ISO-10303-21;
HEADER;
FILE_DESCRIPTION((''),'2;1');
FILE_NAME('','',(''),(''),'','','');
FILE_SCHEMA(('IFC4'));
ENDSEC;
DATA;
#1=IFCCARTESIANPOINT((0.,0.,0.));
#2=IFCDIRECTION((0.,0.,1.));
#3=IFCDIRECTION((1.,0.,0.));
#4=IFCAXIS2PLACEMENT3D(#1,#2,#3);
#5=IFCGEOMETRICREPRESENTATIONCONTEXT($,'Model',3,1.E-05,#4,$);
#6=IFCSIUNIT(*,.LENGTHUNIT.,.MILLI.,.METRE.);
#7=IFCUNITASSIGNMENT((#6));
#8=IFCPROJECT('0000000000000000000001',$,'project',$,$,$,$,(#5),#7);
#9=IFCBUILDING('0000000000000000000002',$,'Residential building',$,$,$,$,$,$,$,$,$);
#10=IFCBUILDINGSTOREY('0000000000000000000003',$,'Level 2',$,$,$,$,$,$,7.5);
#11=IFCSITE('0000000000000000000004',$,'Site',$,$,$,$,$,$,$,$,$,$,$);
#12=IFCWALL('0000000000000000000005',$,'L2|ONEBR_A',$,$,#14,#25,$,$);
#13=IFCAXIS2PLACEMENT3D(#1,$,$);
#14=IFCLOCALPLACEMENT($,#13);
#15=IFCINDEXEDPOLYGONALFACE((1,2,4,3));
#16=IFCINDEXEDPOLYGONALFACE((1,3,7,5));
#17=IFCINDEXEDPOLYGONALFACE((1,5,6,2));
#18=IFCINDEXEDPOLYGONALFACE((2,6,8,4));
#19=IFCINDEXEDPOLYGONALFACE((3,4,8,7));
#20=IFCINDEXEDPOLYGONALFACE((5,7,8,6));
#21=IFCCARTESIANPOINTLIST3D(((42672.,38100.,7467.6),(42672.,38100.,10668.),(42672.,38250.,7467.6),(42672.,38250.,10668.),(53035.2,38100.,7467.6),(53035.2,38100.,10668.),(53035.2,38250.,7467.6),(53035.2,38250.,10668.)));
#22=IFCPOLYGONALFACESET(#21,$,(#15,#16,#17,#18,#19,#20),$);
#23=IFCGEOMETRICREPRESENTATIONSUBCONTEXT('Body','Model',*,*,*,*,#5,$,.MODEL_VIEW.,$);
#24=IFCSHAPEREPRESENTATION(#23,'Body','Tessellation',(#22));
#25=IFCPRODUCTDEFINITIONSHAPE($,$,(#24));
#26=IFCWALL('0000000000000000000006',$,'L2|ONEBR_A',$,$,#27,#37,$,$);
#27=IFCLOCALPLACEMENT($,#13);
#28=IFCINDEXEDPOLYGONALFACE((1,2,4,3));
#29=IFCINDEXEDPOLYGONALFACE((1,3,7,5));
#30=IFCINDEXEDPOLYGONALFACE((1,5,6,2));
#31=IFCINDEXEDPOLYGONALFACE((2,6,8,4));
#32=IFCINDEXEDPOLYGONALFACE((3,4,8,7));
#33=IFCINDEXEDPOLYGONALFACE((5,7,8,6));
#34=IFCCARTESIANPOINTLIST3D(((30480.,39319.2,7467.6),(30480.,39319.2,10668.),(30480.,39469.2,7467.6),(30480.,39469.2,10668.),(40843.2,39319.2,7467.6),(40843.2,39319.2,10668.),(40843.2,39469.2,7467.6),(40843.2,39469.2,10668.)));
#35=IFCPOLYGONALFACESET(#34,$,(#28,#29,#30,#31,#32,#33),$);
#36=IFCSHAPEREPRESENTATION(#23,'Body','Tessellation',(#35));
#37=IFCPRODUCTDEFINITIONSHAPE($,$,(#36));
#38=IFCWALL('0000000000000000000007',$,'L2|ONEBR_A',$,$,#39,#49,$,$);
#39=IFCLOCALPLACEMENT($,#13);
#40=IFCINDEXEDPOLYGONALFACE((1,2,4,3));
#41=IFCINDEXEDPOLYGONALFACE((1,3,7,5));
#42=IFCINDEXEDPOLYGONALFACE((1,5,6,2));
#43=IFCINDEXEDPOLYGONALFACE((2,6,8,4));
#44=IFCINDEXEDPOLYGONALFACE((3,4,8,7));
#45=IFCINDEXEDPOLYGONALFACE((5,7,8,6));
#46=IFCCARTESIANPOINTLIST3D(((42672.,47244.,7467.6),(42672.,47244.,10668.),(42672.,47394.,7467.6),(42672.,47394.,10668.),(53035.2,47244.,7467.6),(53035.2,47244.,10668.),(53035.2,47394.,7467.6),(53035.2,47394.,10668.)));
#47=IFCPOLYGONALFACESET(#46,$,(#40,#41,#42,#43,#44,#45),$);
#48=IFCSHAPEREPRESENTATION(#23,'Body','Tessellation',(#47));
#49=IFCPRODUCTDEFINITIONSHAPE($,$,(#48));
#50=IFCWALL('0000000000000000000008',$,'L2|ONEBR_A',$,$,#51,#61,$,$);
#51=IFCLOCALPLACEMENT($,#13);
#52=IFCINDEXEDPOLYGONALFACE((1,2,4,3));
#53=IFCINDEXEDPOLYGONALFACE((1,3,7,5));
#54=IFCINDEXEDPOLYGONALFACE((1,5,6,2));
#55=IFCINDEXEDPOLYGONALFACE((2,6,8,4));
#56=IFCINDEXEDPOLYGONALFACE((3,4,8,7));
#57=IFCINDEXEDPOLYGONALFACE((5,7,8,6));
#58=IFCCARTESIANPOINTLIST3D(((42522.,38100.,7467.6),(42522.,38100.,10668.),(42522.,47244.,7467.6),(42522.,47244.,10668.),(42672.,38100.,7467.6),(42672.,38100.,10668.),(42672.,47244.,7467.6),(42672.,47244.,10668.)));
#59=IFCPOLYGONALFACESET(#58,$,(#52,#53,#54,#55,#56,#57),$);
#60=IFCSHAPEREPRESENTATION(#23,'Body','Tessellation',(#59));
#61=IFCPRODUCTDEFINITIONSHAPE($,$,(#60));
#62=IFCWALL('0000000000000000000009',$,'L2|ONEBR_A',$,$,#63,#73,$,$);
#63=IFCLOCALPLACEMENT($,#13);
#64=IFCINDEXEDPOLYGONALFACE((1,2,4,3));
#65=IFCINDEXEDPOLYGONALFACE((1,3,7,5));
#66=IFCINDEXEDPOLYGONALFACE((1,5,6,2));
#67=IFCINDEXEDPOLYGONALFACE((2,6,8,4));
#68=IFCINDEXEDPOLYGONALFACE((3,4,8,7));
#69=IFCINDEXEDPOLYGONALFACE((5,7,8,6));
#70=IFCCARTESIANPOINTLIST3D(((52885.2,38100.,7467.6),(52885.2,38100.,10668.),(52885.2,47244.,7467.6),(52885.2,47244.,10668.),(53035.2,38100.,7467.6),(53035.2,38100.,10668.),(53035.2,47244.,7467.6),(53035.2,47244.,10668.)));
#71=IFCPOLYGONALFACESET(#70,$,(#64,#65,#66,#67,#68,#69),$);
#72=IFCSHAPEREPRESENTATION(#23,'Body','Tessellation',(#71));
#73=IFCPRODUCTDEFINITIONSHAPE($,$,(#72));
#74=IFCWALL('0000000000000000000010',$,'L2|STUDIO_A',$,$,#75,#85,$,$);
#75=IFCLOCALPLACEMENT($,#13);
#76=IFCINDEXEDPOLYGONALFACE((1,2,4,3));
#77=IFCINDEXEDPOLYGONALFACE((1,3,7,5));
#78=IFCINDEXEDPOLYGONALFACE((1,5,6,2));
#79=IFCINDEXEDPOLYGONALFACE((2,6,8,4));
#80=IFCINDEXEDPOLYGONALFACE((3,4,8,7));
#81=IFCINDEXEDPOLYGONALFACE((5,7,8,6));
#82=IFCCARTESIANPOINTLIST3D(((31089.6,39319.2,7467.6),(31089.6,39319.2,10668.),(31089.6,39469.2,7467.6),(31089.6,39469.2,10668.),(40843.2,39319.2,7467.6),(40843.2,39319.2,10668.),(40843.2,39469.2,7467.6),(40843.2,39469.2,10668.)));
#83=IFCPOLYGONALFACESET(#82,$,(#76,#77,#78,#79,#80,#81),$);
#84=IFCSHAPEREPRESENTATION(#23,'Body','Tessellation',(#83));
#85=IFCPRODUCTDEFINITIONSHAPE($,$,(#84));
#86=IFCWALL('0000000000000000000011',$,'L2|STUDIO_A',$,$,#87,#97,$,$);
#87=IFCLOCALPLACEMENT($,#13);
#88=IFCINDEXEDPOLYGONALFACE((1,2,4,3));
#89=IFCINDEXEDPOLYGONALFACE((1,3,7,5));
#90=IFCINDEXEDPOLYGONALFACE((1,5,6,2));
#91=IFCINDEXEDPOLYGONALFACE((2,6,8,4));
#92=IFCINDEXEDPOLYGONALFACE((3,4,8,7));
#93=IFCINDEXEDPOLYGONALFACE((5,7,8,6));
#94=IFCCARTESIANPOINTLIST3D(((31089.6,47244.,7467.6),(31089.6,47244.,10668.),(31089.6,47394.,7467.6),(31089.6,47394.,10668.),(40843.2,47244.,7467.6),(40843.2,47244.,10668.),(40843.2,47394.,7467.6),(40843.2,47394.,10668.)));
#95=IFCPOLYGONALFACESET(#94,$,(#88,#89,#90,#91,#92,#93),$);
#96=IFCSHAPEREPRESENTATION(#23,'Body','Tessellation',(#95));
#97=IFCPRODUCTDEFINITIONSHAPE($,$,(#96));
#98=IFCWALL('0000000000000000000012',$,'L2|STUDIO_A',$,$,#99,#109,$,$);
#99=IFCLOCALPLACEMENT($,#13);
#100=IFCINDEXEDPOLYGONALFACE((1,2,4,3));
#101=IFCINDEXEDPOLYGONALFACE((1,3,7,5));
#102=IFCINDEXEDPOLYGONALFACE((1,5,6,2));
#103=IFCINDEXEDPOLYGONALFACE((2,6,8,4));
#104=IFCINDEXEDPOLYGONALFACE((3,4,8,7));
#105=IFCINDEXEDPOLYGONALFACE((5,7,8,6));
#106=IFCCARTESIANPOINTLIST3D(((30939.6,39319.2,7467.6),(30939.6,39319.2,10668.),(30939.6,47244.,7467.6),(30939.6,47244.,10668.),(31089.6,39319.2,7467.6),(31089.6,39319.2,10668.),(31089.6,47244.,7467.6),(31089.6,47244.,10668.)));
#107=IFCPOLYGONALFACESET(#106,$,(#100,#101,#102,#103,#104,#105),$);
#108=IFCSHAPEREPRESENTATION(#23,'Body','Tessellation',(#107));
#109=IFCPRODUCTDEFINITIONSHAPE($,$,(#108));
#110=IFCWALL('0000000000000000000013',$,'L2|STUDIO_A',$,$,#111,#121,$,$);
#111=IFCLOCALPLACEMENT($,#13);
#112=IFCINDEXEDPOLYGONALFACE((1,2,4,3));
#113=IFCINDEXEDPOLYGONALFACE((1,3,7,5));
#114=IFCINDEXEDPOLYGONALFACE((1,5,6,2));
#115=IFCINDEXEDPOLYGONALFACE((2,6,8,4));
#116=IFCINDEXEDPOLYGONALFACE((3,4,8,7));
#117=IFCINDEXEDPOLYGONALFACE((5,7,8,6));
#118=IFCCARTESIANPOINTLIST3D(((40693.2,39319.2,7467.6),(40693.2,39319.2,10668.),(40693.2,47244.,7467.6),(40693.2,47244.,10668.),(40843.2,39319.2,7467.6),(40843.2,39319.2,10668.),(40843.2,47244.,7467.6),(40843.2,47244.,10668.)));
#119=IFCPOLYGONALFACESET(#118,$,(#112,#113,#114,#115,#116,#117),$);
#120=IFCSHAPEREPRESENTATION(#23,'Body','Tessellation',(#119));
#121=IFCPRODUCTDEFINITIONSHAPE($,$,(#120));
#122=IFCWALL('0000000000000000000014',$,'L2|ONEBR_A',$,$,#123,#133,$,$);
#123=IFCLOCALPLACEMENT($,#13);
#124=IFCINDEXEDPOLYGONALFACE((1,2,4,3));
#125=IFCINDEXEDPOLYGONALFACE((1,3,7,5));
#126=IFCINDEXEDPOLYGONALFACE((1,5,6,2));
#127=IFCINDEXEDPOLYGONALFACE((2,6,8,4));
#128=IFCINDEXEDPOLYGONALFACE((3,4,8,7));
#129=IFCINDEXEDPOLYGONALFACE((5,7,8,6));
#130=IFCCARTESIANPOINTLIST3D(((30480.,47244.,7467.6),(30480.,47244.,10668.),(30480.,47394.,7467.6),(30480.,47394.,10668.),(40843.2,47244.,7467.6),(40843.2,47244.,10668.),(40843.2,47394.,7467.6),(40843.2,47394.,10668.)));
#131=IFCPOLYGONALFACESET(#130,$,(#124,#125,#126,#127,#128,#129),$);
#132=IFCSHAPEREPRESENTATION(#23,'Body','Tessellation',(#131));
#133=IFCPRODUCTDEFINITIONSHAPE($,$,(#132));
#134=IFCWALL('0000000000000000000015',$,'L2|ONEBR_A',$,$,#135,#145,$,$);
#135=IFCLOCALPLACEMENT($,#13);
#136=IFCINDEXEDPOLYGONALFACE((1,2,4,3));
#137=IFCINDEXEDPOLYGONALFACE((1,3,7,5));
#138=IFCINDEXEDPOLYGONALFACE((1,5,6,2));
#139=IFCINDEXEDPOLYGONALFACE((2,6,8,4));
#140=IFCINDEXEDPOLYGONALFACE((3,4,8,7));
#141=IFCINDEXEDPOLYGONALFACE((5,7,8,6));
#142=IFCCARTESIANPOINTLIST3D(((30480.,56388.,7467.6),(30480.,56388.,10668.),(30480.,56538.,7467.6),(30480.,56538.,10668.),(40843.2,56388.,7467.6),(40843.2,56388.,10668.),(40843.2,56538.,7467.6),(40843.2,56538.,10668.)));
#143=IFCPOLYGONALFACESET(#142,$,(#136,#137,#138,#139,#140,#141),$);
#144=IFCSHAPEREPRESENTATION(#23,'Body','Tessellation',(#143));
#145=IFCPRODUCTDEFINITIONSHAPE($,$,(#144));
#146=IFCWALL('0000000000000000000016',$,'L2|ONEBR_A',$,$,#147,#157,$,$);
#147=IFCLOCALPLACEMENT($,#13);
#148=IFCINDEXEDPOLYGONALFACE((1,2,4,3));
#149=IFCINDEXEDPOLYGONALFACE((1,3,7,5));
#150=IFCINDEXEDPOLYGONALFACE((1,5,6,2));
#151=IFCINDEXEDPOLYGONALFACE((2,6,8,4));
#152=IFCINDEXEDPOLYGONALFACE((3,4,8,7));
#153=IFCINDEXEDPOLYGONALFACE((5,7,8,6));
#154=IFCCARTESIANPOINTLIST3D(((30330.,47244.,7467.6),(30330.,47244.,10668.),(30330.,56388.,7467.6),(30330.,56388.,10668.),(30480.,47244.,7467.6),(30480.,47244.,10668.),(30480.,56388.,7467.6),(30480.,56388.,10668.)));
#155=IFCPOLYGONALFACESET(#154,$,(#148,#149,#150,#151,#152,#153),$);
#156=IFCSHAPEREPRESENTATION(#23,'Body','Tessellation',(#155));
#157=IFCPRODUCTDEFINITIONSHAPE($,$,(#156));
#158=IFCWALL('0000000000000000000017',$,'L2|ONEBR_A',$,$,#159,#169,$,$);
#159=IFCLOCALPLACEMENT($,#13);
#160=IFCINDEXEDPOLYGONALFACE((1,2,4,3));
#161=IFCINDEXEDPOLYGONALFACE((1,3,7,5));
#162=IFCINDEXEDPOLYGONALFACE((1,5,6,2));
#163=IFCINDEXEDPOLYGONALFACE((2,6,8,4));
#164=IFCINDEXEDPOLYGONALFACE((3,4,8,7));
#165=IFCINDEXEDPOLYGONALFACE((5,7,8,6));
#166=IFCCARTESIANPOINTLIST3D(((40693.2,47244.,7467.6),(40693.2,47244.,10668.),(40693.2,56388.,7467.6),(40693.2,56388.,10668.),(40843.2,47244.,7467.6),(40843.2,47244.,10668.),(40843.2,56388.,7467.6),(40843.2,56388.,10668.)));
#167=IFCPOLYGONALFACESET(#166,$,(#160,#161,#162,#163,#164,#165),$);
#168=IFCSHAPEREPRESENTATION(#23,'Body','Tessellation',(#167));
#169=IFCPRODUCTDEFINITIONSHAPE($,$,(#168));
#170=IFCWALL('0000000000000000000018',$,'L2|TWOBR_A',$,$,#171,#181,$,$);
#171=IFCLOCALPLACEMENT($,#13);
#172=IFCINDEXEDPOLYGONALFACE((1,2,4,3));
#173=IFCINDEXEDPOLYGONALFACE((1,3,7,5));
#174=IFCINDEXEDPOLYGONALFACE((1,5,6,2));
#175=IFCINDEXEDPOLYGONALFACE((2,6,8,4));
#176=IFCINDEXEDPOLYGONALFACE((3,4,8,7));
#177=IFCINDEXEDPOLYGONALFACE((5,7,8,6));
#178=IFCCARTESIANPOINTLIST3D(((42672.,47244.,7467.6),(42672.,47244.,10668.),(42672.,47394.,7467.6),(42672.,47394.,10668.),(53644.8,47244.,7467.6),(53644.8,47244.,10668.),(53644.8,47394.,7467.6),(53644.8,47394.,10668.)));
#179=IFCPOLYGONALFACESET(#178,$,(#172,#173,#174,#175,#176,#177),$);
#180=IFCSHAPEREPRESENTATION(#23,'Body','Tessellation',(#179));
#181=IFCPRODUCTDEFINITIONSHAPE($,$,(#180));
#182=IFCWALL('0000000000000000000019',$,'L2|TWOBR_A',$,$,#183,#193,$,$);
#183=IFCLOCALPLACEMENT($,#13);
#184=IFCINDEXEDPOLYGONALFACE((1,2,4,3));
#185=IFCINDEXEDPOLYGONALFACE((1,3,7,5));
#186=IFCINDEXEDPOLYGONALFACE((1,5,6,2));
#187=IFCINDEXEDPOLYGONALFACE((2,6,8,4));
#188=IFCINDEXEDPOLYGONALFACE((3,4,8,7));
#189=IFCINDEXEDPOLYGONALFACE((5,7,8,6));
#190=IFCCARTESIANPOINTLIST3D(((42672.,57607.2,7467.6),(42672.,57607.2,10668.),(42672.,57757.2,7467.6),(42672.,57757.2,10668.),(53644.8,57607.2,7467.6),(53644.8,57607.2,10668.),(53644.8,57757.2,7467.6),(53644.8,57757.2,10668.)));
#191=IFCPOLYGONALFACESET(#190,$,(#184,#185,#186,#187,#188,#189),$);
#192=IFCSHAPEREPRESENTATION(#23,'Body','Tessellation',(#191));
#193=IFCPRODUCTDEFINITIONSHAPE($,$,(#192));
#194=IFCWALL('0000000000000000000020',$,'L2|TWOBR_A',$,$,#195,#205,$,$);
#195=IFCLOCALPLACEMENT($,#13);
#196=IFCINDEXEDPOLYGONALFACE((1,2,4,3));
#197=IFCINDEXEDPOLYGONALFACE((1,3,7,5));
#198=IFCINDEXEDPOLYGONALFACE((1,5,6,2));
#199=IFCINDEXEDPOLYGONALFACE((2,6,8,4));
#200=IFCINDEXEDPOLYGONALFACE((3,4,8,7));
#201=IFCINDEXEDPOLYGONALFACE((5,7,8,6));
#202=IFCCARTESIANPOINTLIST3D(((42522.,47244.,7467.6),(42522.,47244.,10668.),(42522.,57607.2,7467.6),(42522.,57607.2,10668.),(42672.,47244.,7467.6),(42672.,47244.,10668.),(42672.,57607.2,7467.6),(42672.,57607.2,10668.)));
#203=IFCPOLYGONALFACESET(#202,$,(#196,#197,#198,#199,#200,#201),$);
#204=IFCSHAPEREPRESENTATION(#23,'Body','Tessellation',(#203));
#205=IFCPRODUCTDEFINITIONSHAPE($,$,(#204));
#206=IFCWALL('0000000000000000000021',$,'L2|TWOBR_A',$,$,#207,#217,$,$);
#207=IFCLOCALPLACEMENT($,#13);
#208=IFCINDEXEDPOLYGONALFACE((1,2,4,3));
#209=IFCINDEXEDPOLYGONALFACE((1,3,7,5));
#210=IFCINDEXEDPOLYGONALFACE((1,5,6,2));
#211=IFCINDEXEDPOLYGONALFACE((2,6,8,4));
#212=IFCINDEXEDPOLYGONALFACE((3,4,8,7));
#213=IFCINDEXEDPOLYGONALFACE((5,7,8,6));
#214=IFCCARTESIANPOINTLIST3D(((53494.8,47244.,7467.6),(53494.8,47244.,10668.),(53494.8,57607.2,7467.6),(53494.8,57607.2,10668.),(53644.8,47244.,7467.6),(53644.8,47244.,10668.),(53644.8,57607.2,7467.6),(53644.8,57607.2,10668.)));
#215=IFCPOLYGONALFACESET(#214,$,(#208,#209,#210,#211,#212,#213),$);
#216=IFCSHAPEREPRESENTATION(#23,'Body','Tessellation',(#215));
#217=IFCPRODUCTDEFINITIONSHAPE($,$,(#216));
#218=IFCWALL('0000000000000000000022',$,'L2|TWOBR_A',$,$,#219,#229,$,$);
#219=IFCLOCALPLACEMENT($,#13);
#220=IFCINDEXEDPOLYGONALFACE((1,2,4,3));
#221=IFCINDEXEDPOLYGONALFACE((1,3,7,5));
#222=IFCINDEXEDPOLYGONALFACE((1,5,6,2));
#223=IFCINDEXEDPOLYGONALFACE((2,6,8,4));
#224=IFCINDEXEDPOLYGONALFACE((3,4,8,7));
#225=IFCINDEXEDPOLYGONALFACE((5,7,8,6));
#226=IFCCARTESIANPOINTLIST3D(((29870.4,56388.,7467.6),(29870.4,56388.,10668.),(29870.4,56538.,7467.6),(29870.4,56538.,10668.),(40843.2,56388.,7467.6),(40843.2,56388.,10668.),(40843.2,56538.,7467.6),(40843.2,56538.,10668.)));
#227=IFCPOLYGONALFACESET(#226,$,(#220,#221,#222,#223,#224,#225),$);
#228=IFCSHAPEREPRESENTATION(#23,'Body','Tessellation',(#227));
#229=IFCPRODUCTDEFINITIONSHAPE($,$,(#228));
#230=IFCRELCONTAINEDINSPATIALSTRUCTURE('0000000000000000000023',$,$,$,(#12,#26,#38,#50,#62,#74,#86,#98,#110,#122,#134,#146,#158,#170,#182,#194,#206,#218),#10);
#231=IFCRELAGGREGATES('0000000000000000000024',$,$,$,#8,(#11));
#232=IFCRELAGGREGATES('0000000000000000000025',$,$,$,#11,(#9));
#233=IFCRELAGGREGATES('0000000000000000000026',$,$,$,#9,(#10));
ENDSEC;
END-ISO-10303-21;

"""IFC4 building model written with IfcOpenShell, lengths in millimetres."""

from ifc_helpers import new_model, si_unit, frame, origin_with_axes, place, context, subcontext, project, spatial, indexed_curve, outline, extrude, element, save


model = new_model("IFC4")

# Units and contexts
model_context = context("Model", 3, precision=1e-05, world=origin_with_axes())
body_context = subcontext(model_context, "Body", "Model", "MODEL_VIEW")
ifc_project = project(units=[si_unit("LENGTHUNIT", "METRE", prefix="MILLI")], contexts=[model_context])

# Site, building, storey
site = spatial("IfcSite", under=ifc_project, Name="Site")
building = spatial("IfcBuilding", under=site, Name="Residential building")
storey = spatial("IfcBuildingStorey", under=building, Name="Level 2", Elevation=7.5)

# Walls
for number, where, z_axis, x_axis, name in (
    (1, (42672.0, 38100.0, 7467.6), (0.0, 0.0, 1.0), (1.0, 0.0, 0.0), "L2|ONEBR_A"),
    (2, (30480.0, 39319.2, 7467.6), (0.0, 0.0, 1.0), (1.0, 0.0, 0.0), "L2|ONEBR_A"),
    (3, (42672.0, 47244.0, 7467.6), (0.0, 0.0, 1.0), (1.0, 0.0, 0.0), "L2|ONEBR_A"),
):
    element("IfcWall", number, at=place(None, frame(where, z_axis=z_axis, x_axis=x_axis)), inside=storey, Name=name, context=body_context, shape_type="SweptSolid", body=[
        extrude(outline(indexed_curve([(0.0, 0.0), (0.0, 150.0), (10363.2, 150.0), (10363.2, 0.0), (0.0, 0.0)], self_intersect=False)), origin_with_axes(), (0.0, 0.0, 1.0), 3200.4),
    ])
for number, where, z_axis, x_axis, name in (
    (4, (42672.0, 38100.0, 7467.6), (0.0, 0.0, 1.0), (0.0, 1.0, 0.0), "L2|ONEBR_A"),
    (5, (53035.2, 38100.0, 7467.6), (0.0, 0.0, 1.0), (0.0, 1.0, 0.0), "L2|ONEBR_A"),
):
    element("IfcWall", number, at=place(None, frame(where, z_axis=z_axis, x_axis=x_axis)), inside=storey, Name=name, context=body_context, shape_type="SweptSolid", body=[
        extrude(outline(indexed_curve([(0.0, 0.0), (0.0, 150.0), (9144.0, 150.0), (9144.0, 0.0), (0.0, 0.0)], self_intersect=False)), origin_with_axes(), (0.0, 0.0, 1.0), 3200.4),
    ])
for number, where, z_axis, x_axis, name in (
    (6, (31089.6, 39319.2, 7467.6), (0.0, 0.0, 1.0), (1.0, 0.0, 0.0), "L2|STUDIO_A"),
    (7, (31089.6, 47244.0, 7467.6), (0.0, 0.0, 1.0), (1.0, 0.0, 0.0), "L2|STUDIO_A"),
):
    element("IfcWall", number, at=place(None, frame(where, z_axis=z_axis, x_axis=x_axis)), inside=storey, Name=name, context=body_context, shape_type="SweptSolid", body=[
        extrude(outline(indexed_curve([(0.0, 0.0), (0.0, 150.0), (9753.6, 150.0), (9753.6, 0.0), (0.0, 0.0)], self_intersect=False)), origin_with_axes(), (0.0, 0.0, 1.0), 3200.4),
    ])
for number, where, z_axis, x_axis, name in (
    (8, (31089.6, 39319.2, 7467.6), (0.0, 0.0, 1.0), (0.0, 1.0, 0.0), "L2|STUDIO_A"),
    (9, (40843.2, 39319.2, 7467.6), (0.0, 0.0, 1.0), (0.0, 1.0, 0.0), "L2|STUDIO_A"),
):
    element("IfcWall", number, at=place(None, frame(where, z_axis=z_axis, x_axis=x_axis)), inside=storey, Name=name, context=body_context, shape_type="SweptSolid", body=[
        extrude(outline(indexed_curve([(0.0, 0.0), (0.0, 150.0), (7924.8, 150.0), (7924.8, 0.0), (0.0, 0.0)], self_intersect=False)), origin_with_axes(), (0.0, 0.0, 1.0), 3200.4),
    ])
for number, where, z_axis, x_axis, name in (
    (10, (30480.0, 47244.0, 7467.6), (0.0, 0.0, 1.0), (1.0, 0.0, 0.0), "L2|ONEBR_A"),
    (11, (30480.0, 56388.0, 7467.6), (0.0, 0.0, 1.0), (1.0, 0.0, 0.0), "L2|ONEBR_A"),
):
    element("IfcWall", number, at=place(None, frame(where, z_axis=z_axis, x_axis=x_axis)), inside=storey, Name=name, context=body_context, shape_type="SweptSolid", body=[
        extrude(outline(indexed_curve([(0.0, 0.0), (0.0, 150.0), (10363.2, 150.0), (10363.2, 0.0), (0.0, 0.0)], self_intersect=False)), origin_with_axes(), (0.0, 0.0, 1.0), 3200.4),
    ])
for number, where, z_axis, x_axis, name in (
    (12, (30480.0, 47244.0, 7467.6), (0.0, 0.0, 1.0), (0.0, 1.0, 0.0), "L2|ONEBR_A"),
    (13, (40843.2, 47244.0, 7467.6), (0.0, 0.0, 1.0), (0.0, 1.0, 0.0), "L2|ONEBR_A"),
):
    element("IfcWall", number, at=place(None, frame(where, z_axis=z_axis, x_axis=x_axis)), inside=storey, Name=name, context=body_context, shape_type="SweptSolid", body=[
        extrude(outline(indexed_curve([(0.0, 0.0), (0.0, 150.0), (9144.0, 150.0), (9144.0, 0.0), (0.0, 0.0)], self_intersect=False)), origin_with_axes(), (0.0, 0.0, 1.0), 3200.4),
    ])
for number, where, z_axis, x_axis, name in (
    (14, (42672.0, 47244.0, 7467.6), (0.0, 0.0, 1.0), (1.0, 0.0, 0.0), "L2|TWOBR_A"),
    (15, (42672.0, 57607.2, 7467.6), (0.0, 0.0, 1.0), (1.0, 0.0, 0.0), "L2|TWOBR_A"),
):
    element("IfcWall", number, at=place(None, frame(where, z_axis=z_axis, x_axis=x_axis)), inside=storey, Name=name, context=body_context, shape_type="SweptSolid", body=[
        extrude(outline(indexed_curve([(0.0, 0.0), (0.0, 150.0), (10972.8, 150.0), (10972.8, 0.0), (0.0, 0.0)], self_intersect=False)), origin_with_axes(), (0.0, 0.0, 1.0), 3200.4),
    ])
for number, where, z_axis, x_axis, name in (
    (16, (42672.0, 47244.0, 7467.6), (0.0, 0.0, 1.0), (0.0, 1.0, 0.0), "L2|TWOBR_A"),
    (17, (53644.8, 47244.0, 7467.6), (0.0, 0.0, 1.0), (0.0, 1.0, 0.0), "L2|TWOBR_A"),
):
    element("IfcWall", number, at=place(None, frame(where, z_axis=z_axis, x_axis=x_axis)), inside=storey, Name=name, context=body_context, shape_type="SweptSolid", body=[
        extrude(outline(indexed_curve([(0.0, 0.0), (0.0, 150.0), (10363.2, 150.0), (10363.2, 0.0), (0.0, 0.0)], self_intersect=False)), origin_with_axes(), (0.0, 0.0, 1.0), 3200.4),
    ])
for number, where, z_axis, x_axis, name in (
    (18, (29870.4, 56388.0, 7467.6), (0.0, 0.0, 1.0), (1.0, 0.0, 0.0), "L2|TWOBR_A"),
):
    element("IfcWall", number, at=place(None, frame(where, z_axis=z_axis, x_axis=x_axis)), inside=storey, Name=name, context=body_context, shape_type="SweptSolid", body=[
        extrude(outline(indexed_curve([(0.0, 0.0), (0.0, 150.0), (10972.8, 150.0), (10972.8, 0.0), (0.0, 0.0)], self_intersect=False)), origin_with_axes(), (0.0, 0.0, 1.0), 3200.4),
    ])

save(model, "model.ifc")
